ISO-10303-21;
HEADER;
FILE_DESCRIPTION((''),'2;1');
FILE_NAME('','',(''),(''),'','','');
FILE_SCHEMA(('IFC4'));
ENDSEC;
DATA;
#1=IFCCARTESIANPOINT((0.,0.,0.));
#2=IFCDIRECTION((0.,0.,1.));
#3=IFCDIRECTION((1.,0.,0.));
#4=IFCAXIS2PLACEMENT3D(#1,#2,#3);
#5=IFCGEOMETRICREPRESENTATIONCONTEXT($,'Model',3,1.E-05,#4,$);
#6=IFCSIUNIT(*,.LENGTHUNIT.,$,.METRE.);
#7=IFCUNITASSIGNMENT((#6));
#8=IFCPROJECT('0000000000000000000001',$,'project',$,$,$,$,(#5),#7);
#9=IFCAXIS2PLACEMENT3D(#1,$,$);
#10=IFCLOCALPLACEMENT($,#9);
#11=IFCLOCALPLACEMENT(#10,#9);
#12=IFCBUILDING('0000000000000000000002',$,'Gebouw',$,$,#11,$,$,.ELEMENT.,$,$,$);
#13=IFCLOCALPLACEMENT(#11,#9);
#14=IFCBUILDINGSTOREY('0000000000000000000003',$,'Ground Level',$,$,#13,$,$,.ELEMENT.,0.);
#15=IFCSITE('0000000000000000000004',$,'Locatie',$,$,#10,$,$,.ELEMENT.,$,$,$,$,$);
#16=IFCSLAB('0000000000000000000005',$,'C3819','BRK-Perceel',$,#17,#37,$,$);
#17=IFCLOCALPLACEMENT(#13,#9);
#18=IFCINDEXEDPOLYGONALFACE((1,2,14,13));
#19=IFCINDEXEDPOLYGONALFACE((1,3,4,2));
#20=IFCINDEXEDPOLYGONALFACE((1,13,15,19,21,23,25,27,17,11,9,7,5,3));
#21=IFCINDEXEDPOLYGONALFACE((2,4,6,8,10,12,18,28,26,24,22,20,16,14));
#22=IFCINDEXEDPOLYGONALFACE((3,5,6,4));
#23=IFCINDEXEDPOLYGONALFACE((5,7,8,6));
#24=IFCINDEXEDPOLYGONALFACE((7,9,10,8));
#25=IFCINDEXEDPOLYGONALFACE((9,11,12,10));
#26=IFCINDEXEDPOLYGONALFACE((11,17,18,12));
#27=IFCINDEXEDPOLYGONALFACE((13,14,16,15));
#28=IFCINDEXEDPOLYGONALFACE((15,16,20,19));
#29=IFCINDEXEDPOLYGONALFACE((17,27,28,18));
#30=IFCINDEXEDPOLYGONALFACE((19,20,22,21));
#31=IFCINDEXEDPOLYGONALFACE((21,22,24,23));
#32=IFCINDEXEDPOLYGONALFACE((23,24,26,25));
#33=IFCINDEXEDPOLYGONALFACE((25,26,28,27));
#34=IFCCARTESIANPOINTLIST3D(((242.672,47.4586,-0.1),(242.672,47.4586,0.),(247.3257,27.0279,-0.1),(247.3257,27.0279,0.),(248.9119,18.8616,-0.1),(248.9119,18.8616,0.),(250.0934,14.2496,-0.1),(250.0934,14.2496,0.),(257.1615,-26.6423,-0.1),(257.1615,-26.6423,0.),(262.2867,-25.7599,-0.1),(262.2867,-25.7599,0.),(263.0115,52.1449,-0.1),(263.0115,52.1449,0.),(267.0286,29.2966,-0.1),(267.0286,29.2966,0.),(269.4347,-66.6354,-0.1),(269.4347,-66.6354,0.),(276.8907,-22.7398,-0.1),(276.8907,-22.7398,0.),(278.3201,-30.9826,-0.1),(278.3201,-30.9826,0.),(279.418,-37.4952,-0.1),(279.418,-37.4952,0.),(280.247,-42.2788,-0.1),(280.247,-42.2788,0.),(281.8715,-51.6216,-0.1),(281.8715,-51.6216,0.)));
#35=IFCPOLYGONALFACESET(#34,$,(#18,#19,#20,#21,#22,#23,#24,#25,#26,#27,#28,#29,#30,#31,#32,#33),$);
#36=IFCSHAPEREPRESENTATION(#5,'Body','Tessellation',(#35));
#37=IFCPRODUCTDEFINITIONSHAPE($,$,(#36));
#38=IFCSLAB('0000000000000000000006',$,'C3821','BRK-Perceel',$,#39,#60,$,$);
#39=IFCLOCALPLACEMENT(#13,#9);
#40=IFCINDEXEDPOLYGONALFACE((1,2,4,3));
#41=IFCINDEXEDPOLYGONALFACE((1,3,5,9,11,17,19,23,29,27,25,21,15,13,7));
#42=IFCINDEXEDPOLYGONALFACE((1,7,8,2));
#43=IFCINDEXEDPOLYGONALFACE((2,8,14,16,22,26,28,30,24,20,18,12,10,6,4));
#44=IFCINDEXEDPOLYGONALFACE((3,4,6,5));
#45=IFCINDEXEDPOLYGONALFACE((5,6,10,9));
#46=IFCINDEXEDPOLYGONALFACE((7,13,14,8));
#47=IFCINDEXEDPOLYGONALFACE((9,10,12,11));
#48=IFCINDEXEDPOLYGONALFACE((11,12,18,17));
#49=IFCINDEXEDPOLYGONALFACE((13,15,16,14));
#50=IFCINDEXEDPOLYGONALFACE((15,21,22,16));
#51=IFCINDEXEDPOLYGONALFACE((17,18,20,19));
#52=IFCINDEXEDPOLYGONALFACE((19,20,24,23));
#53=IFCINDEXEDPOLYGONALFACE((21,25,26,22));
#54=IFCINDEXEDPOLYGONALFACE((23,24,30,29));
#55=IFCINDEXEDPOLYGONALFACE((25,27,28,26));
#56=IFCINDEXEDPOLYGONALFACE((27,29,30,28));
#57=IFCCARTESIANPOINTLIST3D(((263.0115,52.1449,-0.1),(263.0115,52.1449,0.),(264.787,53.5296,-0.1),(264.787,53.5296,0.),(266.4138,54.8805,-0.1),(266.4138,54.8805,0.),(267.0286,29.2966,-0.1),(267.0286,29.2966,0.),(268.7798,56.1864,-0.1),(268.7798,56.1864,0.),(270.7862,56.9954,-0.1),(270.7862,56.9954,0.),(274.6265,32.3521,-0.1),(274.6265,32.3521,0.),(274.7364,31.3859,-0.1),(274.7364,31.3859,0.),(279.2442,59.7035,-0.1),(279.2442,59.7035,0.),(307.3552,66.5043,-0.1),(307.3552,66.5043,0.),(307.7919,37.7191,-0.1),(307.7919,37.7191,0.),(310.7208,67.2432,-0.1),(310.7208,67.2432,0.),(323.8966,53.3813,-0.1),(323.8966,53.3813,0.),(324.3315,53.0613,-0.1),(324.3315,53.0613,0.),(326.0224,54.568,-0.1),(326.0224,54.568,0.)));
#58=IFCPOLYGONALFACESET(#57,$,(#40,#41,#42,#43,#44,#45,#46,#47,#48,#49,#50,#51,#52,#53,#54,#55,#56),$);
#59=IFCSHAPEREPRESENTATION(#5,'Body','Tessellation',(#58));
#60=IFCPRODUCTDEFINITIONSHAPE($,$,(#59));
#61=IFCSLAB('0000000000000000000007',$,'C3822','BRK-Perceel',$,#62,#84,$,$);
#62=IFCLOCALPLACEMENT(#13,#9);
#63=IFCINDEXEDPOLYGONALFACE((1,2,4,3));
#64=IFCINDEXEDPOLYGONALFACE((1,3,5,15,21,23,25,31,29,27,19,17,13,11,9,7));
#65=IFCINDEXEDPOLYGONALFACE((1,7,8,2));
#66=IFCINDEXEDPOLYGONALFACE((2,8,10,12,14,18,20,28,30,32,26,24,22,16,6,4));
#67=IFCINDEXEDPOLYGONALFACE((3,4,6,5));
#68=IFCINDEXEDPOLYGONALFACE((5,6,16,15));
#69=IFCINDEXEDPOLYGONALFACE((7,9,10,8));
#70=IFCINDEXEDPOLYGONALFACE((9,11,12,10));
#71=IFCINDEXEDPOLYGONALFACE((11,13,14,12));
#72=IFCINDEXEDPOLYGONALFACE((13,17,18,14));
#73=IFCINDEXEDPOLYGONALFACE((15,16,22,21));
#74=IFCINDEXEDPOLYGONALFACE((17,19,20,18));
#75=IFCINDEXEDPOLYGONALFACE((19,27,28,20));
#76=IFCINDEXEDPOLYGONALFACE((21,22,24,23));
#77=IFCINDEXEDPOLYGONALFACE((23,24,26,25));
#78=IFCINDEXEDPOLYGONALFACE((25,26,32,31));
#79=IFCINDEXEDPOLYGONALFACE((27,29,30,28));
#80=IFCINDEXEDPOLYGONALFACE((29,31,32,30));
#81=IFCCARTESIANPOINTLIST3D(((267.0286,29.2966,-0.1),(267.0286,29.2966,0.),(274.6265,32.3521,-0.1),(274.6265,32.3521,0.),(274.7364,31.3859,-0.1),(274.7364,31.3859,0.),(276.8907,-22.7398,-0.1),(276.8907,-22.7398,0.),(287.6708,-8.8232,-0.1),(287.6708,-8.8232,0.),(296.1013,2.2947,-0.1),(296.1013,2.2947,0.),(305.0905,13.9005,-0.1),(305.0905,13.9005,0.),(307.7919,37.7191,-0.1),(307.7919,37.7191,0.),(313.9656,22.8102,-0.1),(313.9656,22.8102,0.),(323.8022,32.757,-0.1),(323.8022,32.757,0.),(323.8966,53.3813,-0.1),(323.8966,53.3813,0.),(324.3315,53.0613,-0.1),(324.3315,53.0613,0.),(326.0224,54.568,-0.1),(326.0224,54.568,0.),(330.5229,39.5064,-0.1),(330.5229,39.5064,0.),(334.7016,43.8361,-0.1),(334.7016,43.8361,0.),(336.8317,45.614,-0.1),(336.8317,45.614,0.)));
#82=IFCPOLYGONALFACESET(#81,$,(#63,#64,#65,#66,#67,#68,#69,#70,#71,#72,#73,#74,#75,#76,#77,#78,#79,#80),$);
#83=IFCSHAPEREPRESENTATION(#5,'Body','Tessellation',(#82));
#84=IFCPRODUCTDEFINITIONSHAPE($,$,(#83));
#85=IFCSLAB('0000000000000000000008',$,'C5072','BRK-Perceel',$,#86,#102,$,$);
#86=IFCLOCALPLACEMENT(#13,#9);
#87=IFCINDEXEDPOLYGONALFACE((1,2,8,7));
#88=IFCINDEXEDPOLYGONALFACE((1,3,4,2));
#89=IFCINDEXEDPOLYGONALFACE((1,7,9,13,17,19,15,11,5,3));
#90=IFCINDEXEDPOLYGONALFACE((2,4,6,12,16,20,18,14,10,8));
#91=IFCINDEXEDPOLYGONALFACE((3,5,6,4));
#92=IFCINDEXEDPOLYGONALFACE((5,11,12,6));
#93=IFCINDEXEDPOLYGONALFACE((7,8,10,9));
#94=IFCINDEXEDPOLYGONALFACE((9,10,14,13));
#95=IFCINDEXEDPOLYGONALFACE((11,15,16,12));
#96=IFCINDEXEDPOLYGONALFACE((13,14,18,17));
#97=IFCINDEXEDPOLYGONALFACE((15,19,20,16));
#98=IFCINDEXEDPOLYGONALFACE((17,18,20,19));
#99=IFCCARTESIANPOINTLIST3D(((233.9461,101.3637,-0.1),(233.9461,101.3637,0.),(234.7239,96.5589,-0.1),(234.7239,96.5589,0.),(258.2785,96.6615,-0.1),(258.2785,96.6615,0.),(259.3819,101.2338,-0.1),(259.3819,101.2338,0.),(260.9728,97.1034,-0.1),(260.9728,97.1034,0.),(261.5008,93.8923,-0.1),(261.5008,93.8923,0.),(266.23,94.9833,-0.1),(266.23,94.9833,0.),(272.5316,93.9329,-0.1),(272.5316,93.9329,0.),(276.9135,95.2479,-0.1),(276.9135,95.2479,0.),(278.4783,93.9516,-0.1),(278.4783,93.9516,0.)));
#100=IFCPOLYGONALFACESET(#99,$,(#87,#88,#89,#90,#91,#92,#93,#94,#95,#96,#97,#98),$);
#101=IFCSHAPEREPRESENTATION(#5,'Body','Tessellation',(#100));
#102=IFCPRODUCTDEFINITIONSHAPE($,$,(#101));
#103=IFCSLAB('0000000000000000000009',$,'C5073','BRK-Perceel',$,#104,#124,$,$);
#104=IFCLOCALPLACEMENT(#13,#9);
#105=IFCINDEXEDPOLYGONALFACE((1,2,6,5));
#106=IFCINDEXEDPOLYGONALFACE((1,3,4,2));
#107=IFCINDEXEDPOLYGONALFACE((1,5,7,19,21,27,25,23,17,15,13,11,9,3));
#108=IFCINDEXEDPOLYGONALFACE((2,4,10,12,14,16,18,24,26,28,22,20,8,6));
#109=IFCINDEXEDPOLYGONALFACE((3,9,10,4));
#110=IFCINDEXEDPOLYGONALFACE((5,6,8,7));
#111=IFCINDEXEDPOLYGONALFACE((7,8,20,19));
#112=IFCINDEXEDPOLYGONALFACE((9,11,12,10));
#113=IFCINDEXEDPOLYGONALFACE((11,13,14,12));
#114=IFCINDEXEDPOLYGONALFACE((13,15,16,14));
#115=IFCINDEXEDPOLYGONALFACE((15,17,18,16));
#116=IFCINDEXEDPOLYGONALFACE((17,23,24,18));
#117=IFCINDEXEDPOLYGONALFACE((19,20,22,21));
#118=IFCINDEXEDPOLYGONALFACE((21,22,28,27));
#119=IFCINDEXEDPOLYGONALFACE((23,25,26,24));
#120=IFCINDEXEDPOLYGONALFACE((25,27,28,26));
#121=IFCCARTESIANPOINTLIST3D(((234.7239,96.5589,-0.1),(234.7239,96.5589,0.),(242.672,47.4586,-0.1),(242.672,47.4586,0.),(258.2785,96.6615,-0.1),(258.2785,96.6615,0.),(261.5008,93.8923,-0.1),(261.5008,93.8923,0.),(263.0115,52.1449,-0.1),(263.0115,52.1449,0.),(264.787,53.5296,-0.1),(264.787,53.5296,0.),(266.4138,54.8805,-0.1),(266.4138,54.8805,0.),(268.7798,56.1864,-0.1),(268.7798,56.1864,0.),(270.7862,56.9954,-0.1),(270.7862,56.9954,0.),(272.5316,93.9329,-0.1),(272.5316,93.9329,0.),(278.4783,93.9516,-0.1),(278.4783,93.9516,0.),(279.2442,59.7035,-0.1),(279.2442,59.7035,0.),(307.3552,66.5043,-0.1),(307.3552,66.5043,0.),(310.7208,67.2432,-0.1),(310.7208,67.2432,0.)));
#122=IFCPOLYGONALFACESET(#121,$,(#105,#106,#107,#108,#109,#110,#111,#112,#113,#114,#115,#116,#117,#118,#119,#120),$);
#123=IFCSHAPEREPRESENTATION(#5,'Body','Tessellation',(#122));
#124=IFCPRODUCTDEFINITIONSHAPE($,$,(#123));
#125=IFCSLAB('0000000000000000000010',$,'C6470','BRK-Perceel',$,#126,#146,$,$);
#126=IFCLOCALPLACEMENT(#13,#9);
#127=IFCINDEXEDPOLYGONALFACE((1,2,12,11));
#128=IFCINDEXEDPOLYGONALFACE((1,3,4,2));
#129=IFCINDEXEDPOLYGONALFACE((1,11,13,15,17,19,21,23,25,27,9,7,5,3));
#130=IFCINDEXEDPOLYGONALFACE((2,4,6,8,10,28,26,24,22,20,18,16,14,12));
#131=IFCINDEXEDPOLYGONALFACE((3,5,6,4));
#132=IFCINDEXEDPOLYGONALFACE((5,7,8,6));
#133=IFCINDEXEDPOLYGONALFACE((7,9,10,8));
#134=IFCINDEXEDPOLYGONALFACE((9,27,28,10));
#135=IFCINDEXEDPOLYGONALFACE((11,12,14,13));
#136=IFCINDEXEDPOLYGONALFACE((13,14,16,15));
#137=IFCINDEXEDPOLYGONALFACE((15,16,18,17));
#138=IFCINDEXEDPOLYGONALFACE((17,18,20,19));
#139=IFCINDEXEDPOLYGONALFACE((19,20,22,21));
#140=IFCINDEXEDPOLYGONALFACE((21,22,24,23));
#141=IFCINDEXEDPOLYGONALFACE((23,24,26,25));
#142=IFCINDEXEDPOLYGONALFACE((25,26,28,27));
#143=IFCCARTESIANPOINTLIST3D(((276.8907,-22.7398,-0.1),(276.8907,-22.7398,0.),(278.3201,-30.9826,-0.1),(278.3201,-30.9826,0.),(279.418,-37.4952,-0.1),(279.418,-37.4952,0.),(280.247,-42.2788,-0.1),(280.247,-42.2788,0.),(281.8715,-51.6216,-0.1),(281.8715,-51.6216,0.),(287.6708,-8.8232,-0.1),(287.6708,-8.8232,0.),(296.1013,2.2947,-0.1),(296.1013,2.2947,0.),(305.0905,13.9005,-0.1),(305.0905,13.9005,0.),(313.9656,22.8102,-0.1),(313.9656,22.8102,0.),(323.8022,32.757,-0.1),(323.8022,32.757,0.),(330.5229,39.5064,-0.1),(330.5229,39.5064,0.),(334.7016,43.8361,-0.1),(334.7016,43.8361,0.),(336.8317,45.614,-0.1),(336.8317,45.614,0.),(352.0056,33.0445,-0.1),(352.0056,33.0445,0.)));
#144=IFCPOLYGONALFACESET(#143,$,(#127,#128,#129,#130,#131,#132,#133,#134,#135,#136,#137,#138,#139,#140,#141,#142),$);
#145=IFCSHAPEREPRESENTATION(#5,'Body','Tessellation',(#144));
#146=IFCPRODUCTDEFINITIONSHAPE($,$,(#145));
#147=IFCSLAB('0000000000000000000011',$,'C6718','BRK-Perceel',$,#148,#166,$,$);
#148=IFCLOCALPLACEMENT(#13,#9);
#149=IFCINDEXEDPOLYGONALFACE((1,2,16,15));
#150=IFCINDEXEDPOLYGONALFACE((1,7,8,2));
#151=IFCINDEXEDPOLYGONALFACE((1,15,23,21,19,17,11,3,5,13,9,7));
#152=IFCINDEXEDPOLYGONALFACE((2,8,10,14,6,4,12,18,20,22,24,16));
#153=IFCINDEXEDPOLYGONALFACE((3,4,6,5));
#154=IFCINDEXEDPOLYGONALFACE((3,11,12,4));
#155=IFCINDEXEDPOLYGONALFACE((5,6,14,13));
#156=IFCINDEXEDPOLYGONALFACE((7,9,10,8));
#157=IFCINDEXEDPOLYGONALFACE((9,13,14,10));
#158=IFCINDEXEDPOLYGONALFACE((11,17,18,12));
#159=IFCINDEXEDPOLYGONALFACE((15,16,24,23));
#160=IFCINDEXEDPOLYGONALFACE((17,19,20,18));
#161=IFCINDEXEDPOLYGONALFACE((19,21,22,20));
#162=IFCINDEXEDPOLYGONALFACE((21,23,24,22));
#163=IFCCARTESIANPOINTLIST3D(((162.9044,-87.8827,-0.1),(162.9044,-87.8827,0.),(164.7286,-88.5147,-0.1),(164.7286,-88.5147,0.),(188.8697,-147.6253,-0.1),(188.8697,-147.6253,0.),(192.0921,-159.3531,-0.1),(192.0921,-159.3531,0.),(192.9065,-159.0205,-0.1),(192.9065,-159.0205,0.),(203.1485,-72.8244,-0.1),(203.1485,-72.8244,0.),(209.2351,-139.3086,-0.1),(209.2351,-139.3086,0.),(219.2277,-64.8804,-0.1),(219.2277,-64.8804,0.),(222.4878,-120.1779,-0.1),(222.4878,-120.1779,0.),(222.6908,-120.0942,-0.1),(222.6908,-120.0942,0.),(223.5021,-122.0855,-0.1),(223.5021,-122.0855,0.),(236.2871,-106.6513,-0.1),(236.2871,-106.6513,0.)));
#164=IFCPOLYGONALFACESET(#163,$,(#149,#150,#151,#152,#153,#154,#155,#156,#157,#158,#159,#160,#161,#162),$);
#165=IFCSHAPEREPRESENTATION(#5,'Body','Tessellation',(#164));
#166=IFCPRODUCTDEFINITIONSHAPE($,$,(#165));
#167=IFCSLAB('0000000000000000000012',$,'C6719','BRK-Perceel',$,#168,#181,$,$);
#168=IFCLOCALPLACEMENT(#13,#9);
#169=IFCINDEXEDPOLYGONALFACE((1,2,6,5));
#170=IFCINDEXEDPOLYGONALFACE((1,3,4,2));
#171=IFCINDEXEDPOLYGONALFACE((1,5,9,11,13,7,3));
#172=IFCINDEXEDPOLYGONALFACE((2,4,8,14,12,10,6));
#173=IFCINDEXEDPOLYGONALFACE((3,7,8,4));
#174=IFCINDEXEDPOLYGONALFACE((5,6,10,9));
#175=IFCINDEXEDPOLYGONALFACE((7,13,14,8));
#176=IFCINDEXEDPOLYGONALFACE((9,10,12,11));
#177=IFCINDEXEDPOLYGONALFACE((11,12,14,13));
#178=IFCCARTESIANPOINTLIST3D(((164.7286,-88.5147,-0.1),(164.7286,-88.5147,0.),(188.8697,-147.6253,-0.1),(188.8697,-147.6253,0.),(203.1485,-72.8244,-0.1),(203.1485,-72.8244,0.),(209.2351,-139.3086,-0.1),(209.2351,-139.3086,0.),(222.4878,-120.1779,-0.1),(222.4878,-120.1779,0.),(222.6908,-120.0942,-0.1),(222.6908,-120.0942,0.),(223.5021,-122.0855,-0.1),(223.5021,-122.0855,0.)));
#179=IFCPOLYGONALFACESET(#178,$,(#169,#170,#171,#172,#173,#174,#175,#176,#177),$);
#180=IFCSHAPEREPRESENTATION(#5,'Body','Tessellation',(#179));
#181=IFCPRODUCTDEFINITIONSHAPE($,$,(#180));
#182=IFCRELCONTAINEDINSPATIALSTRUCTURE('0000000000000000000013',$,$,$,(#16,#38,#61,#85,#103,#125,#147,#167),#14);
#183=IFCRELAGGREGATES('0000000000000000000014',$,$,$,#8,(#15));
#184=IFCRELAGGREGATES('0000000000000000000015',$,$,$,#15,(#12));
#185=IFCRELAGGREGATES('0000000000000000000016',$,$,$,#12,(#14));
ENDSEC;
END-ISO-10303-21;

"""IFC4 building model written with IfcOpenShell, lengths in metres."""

from ifc_helpers import new_model, si_unit, frame, origin, origin_with_axes, place, context, project, spatial, polyline, outline, extrude, element, save


model = new_model("IFC4")

# Units and contexts
model_context = context("Model", 3, precision=1e-05, world=origin_with_axes())
ifc_project = project(units=[si_unit("LENGTHUNIT", "METRE")], contexts=[model_context])

# Site, building, storey
site_placement = place(None, origin())
site = spatial("IfcSite", under=ifc_project, at=site_placement, Name="Locatie", CompositionType="ELEMENT")
building_placement = place(site_placement, origin())
building = spatial("IfcBuilding", under=site, at=building_placement, Name="Gebouw", CompositionType="ELEMENT")
storey_placement = place(building_placement, origin())
storey = spatial("IfcBuildingStorey", under=building, at=storey_placement, Name="Ground Level", CompositionType="ELEMENT", Elevation=0.0)

# Slabs
slab_1_placement = place(storey_placement, origin())
element("IfcSlab", 1, at=slab_1_placement, inside=storey, Name="C3819", Description="BRK-Perceel", context=model_context, shape_type="SweptSolid", body=[
    extrude(outline(polyline([(262.2867, -25.7599), (257.1615, -26.6423), (250.0934, 14.2496), (248.9119, 18.8616), (247.3257, 27.0279), (242.672, 47.4586), (263.0115, 52.1449), (267.0286, 29.2966), (276.8907, -22.7398), (278.3201, -30.9826), (279.418, -37.4952), (280.247, -42.2788), (281.8715, -51.6216), (269.4347, -66.6354), (262.2867, -25.7599)])), frame((0.0, 0.0, -0.1), z_axis=(0.0, 0.0, 1.0), x_axis=(1.0, 0.0, 0.0)), (0.0, 0.0, 1.0), 0.1),
])
slab_2_placement = place(storey_placement, origin())
element("IfcSlab", 2, at=slab_2_placement, inside=storey, Name="C3821", Description="BRK-Perceel", context=model_context, shape_type="SweptSolid", body=[
    extrude(outline(polyline([(324.3315, 53.0613), (323.8966, 53.3813), (307.7919, 37.7191), (274.7364, 31.3859), (274.6265, 32.3521), (267.0286, 29.2966), (263.0115, 52.1449), (264.787, 53.5296), (266.4138, 54.8805), (268.7798, 56.1864), (270.7862, 56.9954), (279.2442, 59.7035), (307.3552, 66.5043), (310.7208, 67.2432), (326.0224, 54.568), (324.3315, 53.0613)])), frame((0.0, 0.0, -0.1), z_axis=(0.0, 0.0, 1.0), x_axis=(1.0, 0.0, 0.0)), (0.0, 0.0, 1.0), 0.1),
])
slab_3_placement = place(storey_placement, origin())
element("IfcSlab", 3, at=slab_3_placement, inside=storey, Name="C3822", Description="BRK-Perceel", context=model_context, shape_type="SweptSolid", body=[
    extrude(outline(polyline([(334.7016, 43.8361), (330.5229, 39.5064), (323.8022, 32.757), (313.9656, 22.8102), (305.0905, 13.9005), (296.1013, 2.2947), (287.6708, -8.8232), (276.8907, -22.7398), (267.0286, 29.2966), (274.6265, 32.3521), (274.7364, 31.3859), (307.7919, 37.7191), (323.8966, 53.3813), (324.3315, 53.0613), (326.0224, 54.568), (336.8317, 45.614), (334.7016, 43.8361)])), frame((0.0, 0.0, -0.1), z_axis=(0.0, 0.0, 1.0), x_axis=(1.0, 0.0, 0.0)), (0.0, 0.0, 1.0), 0.1),
])
slab_4_placement = place(storey_placement, origin())
element("IfcSlab", 4, at=slab_4_placement, inside=storey, Name="C5072", Description="BRK-Perceel", context=model_context, shape_type="SweptSolid", body=[
    extrude(outline(polyline([(272.5316, 93.9329), (261.5008, 93.8923), (258.2785, 96.6615), (234.7239, 96.5589), (233.9461, 101.3637), (259.3819, 101.2338), (260.9728, 97.1034), (266.23, 94.9833), (276.9135, 95.2479), (278.4783, 93.9516), (272.5316, 93.9329)])), frame((0.0, 0.0, -0.1), z_axis=(0.0, 0.0, 1.0), x_axis=(1.0, 0.0, 0.0)), (0.0, 0.0, 1.0), 0.1),
])
slab_5_placement = place(storey_placement, origin())
element("IfcSlab", 5, at=slab_5_placement, inside=storey, Name="C5073", Description="BRK-Perceel", context=model_context, shape_type="SweptSolid", body=[
    extrude(outline(polyline([(307.3552, 66.5043), (279.2442, 59.7035), (270.7862, 56.9954), (268.7798, 56.1864), (266.4138, 54.8805), (264.787, 53.5296), (263.0115, 52.1449), (242.672, 47.4586), (234.7239, 96.5589), (258.2785, 96.6615), (261.5008, 93.8923), (272.5316, 93.9329), (278.4783, 93.9516), (310.7208, 67.2432), (307.3552, 66.5043)])), frame((0.0, 0.0, -0.1), z_axis=(0.0, 0.0, 1.0), x_axis=(1.0, 0.0, 0.0)), (0.0, 0.0, 1.0), 0.1),
])
slab_6_placement = place(storey_placement, origin())
element("IfcSlab", 6, at=slab_6_placement, inside=storey, Name="C6470", Description="BRK-Perceel", context=model_context, shape_type="SweptSolid", body=[
    extrude(outline(polyline([(280.247, -42.2788), (279.418, -37.4952), (278.3201, -30.9826), (276.8907, -22.7398), (287.6708, -8.8232), (296.1013, 2.2947), (305.0905, 13.9005), (313.9656, 22.8102), (323.8022, 32.757), (330.5229, 39.5064), (334.7016, 43.8361), (336.8317, 45.614), (352.0056, 33.0445), (281.8715, -51.6216), (280.247, -42.2788)])), frame((0.0, 0.0, -0.1), z_axis=(0.0, 0.0, 1.0), x_axis=(1.0, 0.0, 0.0)), (0.0, 0.0, 1.0), 0.1),
])
slab_7_placement = place(storey_placement, origin())
element("IfcSlab", 7, at=slab_7_placement, inside=storey, Name="C6718", Description="BRK-Perceel", context=model_context, shape_type="SweptSolid", body=[
    extrude(outline(polyline([(192.0921, -159.3531), (162.9044, -87.8827), (219.2277, -64.8804), (236.2871, -106.6513), (223.5021, -122.0855), (222.6908, -120.0942), (222.4878, -120.1779), (203.1485, -72.8244), (164.7286, -88.5147), (188.8697, -147.6253), (209.2351, -139.3086), (192.9065, -159.0205), (192.0921, -159.3531)])), frame((0.0, 0.0, -0.1), z_axis=(0.0, 0.0, 1.0), x_axis=(1.0, 0.0, 0.0)), (0.0, 0.0, 1.0), 0.1),
])
slab_8_placement = place(storey_placement, origin())
element("IfcSlab", 8, at=slab_8_placement, inside=storey, Name="C6719", Description="BRK-Perceel", context=model_context, shape_type="SweptSolid", body=[
    extrude(outline(polyline([(188.8697, -147.6253), (164.7286, -88.5147), (203.1485, -72.8244), (222.4878, -120.1779), (222.6908, -120.0942), (223.5021, -122.0855), (209.2351, -139.3086), (188.8697, -147.6253)])), frame((0.0, 0.0, -0.1), z_axis=(0.0, 0.0, 1.0), x_axis=(1.0, 0.0, 0.0)), (0.0, 0.0, 1.0), 0.1),
])

save(model, "model.ifc")
